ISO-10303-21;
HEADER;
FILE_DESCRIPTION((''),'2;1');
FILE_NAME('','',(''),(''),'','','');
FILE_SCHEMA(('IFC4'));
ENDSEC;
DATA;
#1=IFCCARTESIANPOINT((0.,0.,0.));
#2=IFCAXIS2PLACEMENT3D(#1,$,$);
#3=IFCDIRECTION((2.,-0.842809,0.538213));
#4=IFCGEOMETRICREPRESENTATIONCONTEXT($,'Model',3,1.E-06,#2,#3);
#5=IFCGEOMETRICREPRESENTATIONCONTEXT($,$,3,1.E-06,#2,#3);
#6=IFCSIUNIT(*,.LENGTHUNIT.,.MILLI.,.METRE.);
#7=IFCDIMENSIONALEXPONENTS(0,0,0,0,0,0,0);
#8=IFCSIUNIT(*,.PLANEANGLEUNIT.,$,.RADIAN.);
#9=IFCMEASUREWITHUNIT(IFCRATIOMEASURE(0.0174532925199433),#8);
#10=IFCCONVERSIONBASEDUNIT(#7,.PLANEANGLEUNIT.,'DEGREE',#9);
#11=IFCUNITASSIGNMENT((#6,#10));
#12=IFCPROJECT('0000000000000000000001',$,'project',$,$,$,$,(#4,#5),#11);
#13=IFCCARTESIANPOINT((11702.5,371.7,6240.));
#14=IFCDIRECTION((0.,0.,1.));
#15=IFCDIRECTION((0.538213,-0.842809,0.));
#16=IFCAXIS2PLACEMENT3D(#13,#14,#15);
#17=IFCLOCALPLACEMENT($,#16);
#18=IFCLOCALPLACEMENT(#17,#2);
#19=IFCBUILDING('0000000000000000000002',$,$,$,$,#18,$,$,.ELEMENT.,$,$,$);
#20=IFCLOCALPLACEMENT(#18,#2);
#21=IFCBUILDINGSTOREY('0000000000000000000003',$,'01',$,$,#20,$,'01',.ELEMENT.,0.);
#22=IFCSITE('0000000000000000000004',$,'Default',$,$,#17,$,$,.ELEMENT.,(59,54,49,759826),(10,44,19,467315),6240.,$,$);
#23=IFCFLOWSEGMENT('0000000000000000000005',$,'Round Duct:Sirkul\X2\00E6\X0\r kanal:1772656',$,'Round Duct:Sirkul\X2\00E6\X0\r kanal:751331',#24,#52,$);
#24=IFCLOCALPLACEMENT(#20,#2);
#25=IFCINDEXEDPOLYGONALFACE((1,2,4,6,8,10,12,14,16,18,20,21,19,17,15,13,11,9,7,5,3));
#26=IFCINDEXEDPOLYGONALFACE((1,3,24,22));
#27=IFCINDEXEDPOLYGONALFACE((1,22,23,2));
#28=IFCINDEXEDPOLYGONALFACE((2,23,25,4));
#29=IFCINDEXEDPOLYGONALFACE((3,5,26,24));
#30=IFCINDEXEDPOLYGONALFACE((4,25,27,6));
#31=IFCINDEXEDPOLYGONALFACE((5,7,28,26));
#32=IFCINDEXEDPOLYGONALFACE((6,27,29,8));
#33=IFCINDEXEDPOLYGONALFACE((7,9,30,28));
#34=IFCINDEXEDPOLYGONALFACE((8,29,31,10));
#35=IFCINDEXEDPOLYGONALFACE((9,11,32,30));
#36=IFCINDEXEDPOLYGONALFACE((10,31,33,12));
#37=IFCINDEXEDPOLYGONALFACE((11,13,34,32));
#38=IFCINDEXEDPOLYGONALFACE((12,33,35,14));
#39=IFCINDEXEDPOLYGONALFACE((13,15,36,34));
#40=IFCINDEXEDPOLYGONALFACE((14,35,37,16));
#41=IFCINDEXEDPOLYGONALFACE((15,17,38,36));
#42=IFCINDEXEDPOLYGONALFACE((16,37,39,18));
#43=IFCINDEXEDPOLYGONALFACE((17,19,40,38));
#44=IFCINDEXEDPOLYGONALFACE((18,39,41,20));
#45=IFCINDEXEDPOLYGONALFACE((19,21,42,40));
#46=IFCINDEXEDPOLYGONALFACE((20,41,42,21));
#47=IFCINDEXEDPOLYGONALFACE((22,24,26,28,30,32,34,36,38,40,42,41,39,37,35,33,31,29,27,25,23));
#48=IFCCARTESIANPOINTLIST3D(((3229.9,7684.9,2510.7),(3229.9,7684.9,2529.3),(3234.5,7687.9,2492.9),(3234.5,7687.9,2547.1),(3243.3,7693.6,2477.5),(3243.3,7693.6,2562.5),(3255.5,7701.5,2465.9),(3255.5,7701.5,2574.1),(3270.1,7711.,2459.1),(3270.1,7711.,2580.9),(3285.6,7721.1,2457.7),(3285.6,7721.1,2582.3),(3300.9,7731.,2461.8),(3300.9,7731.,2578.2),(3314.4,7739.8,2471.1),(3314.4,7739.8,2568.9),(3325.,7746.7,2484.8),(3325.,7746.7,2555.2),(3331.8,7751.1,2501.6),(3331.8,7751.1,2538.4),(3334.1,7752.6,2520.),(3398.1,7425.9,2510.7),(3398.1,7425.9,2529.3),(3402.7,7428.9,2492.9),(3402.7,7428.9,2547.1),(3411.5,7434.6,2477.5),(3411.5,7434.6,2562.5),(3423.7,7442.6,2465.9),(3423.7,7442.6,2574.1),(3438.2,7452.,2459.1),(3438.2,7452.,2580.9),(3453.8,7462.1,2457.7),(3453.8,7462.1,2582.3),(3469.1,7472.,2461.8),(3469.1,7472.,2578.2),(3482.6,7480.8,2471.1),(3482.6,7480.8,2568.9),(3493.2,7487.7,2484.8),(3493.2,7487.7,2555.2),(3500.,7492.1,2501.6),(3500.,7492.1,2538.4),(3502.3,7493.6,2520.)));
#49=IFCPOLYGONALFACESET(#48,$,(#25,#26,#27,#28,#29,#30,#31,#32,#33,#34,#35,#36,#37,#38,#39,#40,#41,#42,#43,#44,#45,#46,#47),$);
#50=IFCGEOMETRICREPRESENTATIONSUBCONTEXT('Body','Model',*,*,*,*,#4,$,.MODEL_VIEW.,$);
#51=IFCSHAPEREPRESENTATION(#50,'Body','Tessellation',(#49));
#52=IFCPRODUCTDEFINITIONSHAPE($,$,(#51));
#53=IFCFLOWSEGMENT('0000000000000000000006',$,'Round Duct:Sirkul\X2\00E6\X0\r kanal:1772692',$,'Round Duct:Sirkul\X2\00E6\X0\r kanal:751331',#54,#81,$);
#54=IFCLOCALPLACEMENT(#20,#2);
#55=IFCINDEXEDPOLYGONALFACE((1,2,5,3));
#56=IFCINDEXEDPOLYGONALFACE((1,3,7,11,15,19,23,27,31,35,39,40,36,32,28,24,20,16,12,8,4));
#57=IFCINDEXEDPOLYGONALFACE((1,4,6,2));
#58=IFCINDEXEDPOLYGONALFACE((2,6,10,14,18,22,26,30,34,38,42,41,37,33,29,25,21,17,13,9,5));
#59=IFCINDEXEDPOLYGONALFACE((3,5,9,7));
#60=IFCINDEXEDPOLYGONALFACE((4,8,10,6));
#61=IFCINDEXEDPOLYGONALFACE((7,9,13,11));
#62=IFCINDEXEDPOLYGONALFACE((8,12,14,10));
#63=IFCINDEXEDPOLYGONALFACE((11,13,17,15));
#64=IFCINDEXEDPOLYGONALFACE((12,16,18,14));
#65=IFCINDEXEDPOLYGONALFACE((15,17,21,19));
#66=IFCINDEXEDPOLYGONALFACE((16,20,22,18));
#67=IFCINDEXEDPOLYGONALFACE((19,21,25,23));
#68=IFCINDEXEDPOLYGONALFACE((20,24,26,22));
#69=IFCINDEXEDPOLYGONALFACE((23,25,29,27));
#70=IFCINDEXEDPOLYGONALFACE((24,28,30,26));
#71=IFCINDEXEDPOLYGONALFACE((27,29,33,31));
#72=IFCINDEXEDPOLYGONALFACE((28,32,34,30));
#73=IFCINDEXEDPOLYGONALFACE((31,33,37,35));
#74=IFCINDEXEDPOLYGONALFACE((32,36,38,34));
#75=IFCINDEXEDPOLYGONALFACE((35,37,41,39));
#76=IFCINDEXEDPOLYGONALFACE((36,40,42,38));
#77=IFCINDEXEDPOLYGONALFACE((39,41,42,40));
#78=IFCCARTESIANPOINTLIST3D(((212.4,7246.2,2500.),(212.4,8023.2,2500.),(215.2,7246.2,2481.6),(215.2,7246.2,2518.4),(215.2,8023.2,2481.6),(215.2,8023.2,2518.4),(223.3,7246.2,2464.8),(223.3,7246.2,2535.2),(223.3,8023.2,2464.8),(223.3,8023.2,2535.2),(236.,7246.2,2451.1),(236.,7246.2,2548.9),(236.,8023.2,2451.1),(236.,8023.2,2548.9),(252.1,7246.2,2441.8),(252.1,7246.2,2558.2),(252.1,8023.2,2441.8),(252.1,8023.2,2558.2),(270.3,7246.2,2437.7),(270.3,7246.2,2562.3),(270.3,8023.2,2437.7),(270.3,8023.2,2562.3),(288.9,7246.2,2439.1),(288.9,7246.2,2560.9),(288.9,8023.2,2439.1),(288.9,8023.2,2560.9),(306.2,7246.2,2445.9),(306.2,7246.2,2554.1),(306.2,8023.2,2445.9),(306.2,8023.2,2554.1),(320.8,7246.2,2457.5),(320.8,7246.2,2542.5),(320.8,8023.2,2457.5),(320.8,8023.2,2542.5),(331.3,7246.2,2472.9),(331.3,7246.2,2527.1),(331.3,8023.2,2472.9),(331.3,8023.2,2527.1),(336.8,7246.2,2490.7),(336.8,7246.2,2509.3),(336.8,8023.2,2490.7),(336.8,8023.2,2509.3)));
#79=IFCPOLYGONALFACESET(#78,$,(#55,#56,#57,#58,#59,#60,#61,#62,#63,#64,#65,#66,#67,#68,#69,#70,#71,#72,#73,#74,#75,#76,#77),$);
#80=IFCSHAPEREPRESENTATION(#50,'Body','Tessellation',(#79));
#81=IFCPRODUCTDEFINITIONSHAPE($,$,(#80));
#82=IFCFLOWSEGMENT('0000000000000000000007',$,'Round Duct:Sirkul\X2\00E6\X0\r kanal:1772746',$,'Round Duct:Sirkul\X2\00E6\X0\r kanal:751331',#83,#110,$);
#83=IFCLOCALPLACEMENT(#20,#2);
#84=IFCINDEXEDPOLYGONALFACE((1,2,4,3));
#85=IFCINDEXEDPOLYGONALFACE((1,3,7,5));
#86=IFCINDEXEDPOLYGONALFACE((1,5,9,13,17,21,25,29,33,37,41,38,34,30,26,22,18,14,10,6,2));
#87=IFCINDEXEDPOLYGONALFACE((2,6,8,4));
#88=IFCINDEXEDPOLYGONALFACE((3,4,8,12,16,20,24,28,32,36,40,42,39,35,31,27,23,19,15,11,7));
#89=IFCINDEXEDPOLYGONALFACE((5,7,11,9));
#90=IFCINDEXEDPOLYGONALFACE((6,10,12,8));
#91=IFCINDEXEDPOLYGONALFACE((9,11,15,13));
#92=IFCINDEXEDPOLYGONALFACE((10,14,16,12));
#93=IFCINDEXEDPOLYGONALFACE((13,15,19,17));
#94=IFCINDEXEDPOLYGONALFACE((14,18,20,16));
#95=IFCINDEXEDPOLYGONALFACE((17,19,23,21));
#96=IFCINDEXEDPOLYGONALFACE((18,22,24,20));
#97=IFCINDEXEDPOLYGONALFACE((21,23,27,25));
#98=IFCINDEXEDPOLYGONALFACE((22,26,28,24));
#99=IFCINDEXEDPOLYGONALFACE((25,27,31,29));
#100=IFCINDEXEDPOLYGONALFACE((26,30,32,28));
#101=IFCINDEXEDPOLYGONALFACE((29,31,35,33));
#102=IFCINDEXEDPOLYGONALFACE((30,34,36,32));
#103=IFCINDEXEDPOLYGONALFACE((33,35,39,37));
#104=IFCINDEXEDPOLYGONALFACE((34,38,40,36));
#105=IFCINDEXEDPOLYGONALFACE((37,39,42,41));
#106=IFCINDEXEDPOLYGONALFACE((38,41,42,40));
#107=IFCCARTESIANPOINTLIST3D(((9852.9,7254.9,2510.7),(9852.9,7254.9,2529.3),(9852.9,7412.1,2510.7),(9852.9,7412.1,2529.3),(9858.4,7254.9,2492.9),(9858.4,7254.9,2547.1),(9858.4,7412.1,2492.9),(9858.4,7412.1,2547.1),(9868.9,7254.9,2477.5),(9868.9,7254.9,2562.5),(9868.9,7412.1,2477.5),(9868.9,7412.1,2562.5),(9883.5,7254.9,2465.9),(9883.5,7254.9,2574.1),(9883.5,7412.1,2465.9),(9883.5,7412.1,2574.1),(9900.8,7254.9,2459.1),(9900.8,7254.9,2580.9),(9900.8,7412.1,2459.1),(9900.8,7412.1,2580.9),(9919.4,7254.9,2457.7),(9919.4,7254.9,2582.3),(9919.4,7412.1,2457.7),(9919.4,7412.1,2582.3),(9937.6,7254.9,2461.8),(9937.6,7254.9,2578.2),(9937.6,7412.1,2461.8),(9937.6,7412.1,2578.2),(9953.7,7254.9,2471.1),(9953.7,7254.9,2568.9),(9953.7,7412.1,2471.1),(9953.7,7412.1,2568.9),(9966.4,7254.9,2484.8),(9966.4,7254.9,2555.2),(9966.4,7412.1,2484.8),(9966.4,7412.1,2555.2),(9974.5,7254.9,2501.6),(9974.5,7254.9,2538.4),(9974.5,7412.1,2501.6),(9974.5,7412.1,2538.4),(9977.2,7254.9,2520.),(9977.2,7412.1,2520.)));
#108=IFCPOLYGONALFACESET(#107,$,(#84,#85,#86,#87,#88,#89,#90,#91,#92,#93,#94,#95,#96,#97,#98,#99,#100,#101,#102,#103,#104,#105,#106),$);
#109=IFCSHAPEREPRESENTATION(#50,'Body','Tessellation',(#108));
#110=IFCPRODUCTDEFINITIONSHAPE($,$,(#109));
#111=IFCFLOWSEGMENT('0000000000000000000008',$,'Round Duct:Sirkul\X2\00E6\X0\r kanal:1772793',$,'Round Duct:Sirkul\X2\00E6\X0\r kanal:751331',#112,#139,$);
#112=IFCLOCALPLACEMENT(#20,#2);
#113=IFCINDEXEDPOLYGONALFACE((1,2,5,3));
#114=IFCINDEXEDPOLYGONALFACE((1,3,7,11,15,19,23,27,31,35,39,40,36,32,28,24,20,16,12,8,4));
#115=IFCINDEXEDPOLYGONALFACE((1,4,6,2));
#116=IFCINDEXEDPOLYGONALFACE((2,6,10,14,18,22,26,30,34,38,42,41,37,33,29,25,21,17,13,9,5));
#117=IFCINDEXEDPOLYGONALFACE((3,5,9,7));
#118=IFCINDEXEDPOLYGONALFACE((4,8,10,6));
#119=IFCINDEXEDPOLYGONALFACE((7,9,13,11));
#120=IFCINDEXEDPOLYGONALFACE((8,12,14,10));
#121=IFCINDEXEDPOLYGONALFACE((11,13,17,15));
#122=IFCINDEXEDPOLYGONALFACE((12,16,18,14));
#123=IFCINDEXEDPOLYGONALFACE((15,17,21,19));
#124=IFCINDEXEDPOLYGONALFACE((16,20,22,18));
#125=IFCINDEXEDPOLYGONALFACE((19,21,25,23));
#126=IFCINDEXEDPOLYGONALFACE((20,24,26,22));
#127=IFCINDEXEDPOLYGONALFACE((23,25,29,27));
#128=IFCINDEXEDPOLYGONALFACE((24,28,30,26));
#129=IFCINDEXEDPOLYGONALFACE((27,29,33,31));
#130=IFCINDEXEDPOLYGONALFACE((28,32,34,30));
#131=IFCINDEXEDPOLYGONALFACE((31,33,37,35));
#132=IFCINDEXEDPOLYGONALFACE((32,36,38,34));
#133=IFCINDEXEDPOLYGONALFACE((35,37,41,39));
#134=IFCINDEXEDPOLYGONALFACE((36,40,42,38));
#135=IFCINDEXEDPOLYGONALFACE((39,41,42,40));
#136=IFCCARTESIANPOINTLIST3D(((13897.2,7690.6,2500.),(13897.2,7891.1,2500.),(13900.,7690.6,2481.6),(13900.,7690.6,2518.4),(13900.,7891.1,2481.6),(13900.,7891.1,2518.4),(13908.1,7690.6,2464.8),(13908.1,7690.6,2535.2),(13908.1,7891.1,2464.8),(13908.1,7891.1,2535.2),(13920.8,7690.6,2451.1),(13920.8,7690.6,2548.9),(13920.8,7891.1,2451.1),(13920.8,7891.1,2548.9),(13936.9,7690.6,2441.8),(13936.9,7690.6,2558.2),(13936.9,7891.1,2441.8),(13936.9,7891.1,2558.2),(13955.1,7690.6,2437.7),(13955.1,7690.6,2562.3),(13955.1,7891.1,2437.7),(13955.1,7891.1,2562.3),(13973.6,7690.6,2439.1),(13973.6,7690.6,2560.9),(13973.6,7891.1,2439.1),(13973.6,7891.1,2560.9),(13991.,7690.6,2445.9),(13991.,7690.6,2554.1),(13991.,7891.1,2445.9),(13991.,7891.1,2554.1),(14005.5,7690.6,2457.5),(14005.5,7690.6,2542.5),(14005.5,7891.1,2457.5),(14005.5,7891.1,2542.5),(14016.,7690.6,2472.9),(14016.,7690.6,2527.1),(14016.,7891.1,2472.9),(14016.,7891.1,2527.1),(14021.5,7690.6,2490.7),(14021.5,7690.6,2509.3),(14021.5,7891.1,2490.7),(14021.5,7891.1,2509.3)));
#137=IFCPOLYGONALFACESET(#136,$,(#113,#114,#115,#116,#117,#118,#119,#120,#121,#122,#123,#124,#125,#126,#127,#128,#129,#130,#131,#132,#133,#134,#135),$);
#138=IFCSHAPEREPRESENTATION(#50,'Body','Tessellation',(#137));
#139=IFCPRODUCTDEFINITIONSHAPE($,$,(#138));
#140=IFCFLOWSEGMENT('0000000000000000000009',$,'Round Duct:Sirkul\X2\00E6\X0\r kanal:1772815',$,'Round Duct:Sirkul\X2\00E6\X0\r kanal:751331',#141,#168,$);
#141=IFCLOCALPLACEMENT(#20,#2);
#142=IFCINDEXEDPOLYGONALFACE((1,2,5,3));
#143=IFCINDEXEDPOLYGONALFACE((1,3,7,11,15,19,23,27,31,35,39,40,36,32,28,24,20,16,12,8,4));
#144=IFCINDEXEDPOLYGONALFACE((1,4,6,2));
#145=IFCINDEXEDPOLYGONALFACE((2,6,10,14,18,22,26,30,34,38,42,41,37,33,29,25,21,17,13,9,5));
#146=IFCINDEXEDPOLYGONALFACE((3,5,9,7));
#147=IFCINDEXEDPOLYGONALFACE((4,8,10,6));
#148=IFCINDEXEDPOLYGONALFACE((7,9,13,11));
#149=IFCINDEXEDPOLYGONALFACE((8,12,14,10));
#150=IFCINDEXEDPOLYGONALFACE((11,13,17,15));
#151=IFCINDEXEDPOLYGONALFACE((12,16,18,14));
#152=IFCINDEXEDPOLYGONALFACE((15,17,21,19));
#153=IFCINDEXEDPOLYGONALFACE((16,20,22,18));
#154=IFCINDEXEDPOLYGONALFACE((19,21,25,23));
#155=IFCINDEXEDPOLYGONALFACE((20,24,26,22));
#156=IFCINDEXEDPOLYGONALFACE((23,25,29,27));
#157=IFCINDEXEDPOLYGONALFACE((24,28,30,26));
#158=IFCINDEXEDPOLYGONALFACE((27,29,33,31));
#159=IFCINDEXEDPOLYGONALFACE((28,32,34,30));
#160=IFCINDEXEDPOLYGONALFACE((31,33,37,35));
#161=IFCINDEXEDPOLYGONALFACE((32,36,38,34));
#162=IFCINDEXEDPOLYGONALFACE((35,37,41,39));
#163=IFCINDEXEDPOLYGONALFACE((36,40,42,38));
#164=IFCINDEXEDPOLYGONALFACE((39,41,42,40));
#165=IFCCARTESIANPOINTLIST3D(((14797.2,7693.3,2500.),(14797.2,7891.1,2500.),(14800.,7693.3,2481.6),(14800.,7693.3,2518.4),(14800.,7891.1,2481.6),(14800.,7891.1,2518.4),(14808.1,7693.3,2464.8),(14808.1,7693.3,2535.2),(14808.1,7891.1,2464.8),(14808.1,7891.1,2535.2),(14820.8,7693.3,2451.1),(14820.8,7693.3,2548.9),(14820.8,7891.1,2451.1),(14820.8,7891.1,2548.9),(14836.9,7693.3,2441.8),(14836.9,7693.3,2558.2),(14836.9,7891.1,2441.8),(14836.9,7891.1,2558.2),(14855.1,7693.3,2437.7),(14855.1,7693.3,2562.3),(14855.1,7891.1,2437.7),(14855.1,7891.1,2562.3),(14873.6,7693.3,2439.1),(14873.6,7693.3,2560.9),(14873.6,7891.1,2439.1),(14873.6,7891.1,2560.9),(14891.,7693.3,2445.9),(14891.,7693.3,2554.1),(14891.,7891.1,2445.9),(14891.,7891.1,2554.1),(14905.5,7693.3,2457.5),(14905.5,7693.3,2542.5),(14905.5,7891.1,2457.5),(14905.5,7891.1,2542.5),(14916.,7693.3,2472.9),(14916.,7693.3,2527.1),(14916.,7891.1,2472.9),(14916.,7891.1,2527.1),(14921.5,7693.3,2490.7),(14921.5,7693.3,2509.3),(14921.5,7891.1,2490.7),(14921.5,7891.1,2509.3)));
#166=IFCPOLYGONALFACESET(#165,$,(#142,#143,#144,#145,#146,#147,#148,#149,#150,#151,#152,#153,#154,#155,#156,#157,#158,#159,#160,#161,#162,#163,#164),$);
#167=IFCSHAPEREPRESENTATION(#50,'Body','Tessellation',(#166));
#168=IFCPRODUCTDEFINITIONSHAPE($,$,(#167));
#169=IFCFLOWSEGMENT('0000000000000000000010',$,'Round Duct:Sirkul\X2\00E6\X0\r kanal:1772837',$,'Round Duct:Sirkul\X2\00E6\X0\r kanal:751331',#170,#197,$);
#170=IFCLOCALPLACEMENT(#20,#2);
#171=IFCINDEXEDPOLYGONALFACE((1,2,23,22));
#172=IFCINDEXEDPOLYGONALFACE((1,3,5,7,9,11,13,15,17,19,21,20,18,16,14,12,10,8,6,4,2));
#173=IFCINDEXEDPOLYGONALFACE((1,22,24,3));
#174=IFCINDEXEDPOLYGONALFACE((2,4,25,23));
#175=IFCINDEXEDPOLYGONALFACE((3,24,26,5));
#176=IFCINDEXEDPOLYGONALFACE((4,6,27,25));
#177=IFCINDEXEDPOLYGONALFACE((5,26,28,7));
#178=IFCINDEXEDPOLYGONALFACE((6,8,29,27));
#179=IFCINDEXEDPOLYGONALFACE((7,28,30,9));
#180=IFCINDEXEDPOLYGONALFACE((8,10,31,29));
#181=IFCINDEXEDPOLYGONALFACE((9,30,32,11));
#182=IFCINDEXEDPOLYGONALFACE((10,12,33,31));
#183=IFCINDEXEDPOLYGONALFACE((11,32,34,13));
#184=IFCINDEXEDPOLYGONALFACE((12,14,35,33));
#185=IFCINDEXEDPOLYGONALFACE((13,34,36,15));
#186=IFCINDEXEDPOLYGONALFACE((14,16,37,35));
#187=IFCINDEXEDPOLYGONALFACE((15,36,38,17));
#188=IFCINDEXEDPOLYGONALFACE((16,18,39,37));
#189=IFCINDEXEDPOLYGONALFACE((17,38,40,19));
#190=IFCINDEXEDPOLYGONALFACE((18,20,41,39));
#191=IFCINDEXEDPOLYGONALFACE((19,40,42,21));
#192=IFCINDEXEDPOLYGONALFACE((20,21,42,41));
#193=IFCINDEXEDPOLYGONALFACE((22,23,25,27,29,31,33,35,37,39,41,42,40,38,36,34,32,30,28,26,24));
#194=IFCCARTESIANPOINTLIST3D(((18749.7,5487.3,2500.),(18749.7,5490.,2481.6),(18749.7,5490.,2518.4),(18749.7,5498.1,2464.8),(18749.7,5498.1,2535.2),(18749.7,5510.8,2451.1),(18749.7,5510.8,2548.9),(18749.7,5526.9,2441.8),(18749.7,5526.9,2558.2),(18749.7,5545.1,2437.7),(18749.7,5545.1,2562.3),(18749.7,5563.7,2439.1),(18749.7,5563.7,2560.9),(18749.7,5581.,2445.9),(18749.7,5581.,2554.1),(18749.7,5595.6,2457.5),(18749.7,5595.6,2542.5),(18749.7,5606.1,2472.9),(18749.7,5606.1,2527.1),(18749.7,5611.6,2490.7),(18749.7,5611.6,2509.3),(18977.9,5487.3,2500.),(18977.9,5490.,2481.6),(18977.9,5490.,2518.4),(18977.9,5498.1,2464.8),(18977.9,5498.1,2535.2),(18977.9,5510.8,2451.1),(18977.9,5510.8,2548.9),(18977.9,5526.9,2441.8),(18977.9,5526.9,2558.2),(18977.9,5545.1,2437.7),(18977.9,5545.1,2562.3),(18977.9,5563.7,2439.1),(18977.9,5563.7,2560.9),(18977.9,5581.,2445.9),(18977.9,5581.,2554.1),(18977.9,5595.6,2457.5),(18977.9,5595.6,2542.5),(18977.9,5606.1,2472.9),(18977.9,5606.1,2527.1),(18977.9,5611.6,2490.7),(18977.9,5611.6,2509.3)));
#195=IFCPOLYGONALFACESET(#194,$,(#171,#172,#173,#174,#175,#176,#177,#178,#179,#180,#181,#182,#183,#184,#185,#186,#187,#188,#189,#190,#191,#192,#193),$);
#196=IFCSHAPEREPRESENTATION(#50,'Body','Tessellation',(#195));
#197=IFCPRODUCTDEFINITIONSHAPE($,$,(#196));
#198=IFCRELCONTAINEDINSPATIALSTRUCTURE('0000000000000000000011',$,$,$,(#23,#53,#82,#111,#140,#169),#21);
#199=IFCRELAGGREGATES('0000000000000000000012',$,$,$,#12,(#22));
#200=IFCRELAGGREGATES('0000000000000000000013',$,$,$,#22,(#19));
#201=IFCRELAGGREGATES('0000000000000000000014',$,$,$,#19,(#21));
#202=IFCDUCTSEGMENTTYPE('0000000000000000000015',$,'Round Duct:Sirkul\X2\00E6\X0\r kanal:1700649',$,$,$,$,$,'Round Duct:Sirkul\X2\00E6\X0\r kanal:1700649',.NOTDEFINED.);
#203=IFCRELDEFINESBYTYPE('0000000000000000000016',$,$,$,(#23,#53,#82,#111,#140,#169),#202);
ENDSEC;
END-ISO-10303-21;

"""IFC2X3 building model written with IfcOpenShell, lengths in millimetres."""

from ifc_helpers import new_model, entity, si_unit, converted_unit, direction, frame, frame_2d, origin, origin_2d_with_axis, place, context, subcontext, project, spatial, circle, extrude, type_object, element, save


model = new_model("IFC2X3")

# Units and contexts
model_context = context("Model", 3, precision=1e-06, world=origin(), true_north=direction((2.0, -0.842809, 0.538213)))
context_of_model = context(None, 3, precision=1e-06, world=origin(), true_north=direction((2.0, -0.842809, 0.538213)))
body_context = subcontext(model_context, "Body", "Model", "MODEL_VIEW")
ifc_project = project(units=[si_unit("LENGTHUNIT", "METRE", prefix="MILLI"), converted_unit("PLANEANGLEUNIT", "DEGREE", entity("IfcRatioMeasure", 0.0174532925199433), si_unit("PLANEANGLEUNIT", "RADIAN"), dimensions=[0, 0, 0, 0, 0, 0, 0])], contexts=[model_context, context_of_model])

# Site, building, storey
site_placement = place(None, frame((11702.5, 371.7, 6240.0), z_axis=(0.0, 0.0, 1.0), x_axis=(0.538213, -0.842809, 0.0)))
site = spatial("IfcSite", under=ifc_project, at=site_placement, Name="Default", CompositionType="ELEMENT", RefLatitude=(59, 54, 49, 759826), RefLongitude=(10, 44, 19, 467315), RefElevation=6240.0)
building_placement = place(site_placement, origin())
building = spatial("IfcBuilding", under=site, at=building_placement, CompositionType="ELEMENT")
storey_placement = place(building_placement, origin())
storey = spatial("IfcBuildingStorey", under=building, at=storey_placement, Name="01", LongName="01", CompositionType="ELEMENT", Elevation=0.0)

# Flow segments
duct_segment_type = type_object("IfcDuctSegmentType", Name="Round Duct:Sirkulær kanal:1700649", ElementType="Round Duct:Sirkulær kanal:1700649", PredefinedType="NOTDEFINED")
flow_segment_1_placement = place(storey_placement, origin())
element("IfcFlowSegment", 1, at=flow_segment_1_placement, inside=storey, type_object=duct_segment_type, Name="Round Duct:Sirkulær kanal:1772656", ObjectType="Round Duct:Sirkulær kanal:751331", context=body_context, shape_type="SweptSolid", body=[
    extrude(circle(Radius=62.5, at=origin_2d_with_axis()), frame((3281.7, 7718.6, 2520.0), z_axis=(0.544639, -0.838671, 0.0), x_axis=(0.838671, 0.544639, 0.0)), (0.0, 0.0, 1.0), 308.8),
])
flow_segment_2_placement = place(storey_placement, origin())
element("IfcFlowSegment", 2, at=flow_segment_2_placement, inside=storey, type_object=duct_segment_type, Name="Round Duct:Sirkulær kanal:1772692", ObjectType="Round Duct:Sirkulær kanal:751331", context=body_context, shape_type="SweptSolid", body=[
    extrude(circle(Radius=62.5, at=frame_2d((0.0, 0.0), x_axis=(1.0, 0.0))), frame((274.9, 7246.2, 2500.0), z_axis=(0.0, 1.0, 0.0), x_axis=(-1.0, 0.0, 0.0)), (0.0, 0.0, 1.0), 777.1),
])
flow_segment_3_placement = place(storey_placement, origin())
element("IfcFlowSegment", 3, at=flow_segment_3_placement, inside=storey, type_object=duct_segment_type, Name="Round Duct:Sirkulær kanal:1772746", ObjectType="Round Duct:Sirkulær kanal:751331", context=body_context, shape_type="SweptSolid", body=[
    extrude(circle(Radius=62.5, at=origin_2d_with_axis()), frame((9914.7, 7254.9, 2520.0), z_axis=(0.0, 1.0, 0.0), x_axis=(1.0, 0.0, 0.0)), (0.0, 0.0, 1.0), 157.3),
])
flow_segment_4_placement = place(storey_placement, origin())
element("IfcFlowSegment", 4, at=flow_segment_4_placement, inside=storey, type_object=duct_segment_type, Name="Round Duct:Sirkulær kanal:1772793", ObjectType="Round Duct:Sirkulær kanal:751331", context=body_context, shape_type="SweptSolid", body=[
    extrude(circle(Radius=62.5, at=frame_2d((0.0, 0.0), x_axis=(1.0, 0.0))), frame((13959.7, 7690.6, 2500.0), z_axis=(0.0, 1.0, 0.0), x_axis=(-1.0, 0.0, 0.0)), (0.0, 0.0, 1.0), 200.5),
])
flow_segment_5_placement = place(storey_placement, origin())
element("IfcFlowSegment", 5, at=flow_segment_5_placement, inside=storey, type_object=duct_segment_type, Name="Round Duct:Sirkulær kanal:1772815", ObjectType="Round Duct:Sirkulær kanal:751331", context=body_context, shape_type="SweptSolid", body=[
    extrude(circle(Radius=62.5, at=frame_2d((0.0, 0.0), x_axis=(1.0, 0.0))), frame((14859.7, 7693.3, 2500.0), z_axis=(0.0, 1.0, 0.0), x_axis=(-1.0, 0.0, 0.0)), (0.0, 0.0, 1.0), 197.8),
])
flow_segment_6_placement = place(storey_placement, origin())
element("IfcFlowSegment", 6, at=flow_segment_6_placement, inside=storey, type_object=duct_segment_type, Name="Round Duct:Sirkulær kanal:1772837", ObjectType="Round Duct:Sirkulær kanal:751331", context=body_context, shape_type="SweptSolid", body=[
    extrude(circle(Radius=62.5, at=origin_2d_with_axis()), frame((18749.7, 5549.8, 2500.0), z_axis=(1.0, 0.0, 0.0), x_axis=(0.0, -1.0, 0.0)), (0.0, 0.0, 1.0), 228.2),
])

save(model, "model.ifc")
